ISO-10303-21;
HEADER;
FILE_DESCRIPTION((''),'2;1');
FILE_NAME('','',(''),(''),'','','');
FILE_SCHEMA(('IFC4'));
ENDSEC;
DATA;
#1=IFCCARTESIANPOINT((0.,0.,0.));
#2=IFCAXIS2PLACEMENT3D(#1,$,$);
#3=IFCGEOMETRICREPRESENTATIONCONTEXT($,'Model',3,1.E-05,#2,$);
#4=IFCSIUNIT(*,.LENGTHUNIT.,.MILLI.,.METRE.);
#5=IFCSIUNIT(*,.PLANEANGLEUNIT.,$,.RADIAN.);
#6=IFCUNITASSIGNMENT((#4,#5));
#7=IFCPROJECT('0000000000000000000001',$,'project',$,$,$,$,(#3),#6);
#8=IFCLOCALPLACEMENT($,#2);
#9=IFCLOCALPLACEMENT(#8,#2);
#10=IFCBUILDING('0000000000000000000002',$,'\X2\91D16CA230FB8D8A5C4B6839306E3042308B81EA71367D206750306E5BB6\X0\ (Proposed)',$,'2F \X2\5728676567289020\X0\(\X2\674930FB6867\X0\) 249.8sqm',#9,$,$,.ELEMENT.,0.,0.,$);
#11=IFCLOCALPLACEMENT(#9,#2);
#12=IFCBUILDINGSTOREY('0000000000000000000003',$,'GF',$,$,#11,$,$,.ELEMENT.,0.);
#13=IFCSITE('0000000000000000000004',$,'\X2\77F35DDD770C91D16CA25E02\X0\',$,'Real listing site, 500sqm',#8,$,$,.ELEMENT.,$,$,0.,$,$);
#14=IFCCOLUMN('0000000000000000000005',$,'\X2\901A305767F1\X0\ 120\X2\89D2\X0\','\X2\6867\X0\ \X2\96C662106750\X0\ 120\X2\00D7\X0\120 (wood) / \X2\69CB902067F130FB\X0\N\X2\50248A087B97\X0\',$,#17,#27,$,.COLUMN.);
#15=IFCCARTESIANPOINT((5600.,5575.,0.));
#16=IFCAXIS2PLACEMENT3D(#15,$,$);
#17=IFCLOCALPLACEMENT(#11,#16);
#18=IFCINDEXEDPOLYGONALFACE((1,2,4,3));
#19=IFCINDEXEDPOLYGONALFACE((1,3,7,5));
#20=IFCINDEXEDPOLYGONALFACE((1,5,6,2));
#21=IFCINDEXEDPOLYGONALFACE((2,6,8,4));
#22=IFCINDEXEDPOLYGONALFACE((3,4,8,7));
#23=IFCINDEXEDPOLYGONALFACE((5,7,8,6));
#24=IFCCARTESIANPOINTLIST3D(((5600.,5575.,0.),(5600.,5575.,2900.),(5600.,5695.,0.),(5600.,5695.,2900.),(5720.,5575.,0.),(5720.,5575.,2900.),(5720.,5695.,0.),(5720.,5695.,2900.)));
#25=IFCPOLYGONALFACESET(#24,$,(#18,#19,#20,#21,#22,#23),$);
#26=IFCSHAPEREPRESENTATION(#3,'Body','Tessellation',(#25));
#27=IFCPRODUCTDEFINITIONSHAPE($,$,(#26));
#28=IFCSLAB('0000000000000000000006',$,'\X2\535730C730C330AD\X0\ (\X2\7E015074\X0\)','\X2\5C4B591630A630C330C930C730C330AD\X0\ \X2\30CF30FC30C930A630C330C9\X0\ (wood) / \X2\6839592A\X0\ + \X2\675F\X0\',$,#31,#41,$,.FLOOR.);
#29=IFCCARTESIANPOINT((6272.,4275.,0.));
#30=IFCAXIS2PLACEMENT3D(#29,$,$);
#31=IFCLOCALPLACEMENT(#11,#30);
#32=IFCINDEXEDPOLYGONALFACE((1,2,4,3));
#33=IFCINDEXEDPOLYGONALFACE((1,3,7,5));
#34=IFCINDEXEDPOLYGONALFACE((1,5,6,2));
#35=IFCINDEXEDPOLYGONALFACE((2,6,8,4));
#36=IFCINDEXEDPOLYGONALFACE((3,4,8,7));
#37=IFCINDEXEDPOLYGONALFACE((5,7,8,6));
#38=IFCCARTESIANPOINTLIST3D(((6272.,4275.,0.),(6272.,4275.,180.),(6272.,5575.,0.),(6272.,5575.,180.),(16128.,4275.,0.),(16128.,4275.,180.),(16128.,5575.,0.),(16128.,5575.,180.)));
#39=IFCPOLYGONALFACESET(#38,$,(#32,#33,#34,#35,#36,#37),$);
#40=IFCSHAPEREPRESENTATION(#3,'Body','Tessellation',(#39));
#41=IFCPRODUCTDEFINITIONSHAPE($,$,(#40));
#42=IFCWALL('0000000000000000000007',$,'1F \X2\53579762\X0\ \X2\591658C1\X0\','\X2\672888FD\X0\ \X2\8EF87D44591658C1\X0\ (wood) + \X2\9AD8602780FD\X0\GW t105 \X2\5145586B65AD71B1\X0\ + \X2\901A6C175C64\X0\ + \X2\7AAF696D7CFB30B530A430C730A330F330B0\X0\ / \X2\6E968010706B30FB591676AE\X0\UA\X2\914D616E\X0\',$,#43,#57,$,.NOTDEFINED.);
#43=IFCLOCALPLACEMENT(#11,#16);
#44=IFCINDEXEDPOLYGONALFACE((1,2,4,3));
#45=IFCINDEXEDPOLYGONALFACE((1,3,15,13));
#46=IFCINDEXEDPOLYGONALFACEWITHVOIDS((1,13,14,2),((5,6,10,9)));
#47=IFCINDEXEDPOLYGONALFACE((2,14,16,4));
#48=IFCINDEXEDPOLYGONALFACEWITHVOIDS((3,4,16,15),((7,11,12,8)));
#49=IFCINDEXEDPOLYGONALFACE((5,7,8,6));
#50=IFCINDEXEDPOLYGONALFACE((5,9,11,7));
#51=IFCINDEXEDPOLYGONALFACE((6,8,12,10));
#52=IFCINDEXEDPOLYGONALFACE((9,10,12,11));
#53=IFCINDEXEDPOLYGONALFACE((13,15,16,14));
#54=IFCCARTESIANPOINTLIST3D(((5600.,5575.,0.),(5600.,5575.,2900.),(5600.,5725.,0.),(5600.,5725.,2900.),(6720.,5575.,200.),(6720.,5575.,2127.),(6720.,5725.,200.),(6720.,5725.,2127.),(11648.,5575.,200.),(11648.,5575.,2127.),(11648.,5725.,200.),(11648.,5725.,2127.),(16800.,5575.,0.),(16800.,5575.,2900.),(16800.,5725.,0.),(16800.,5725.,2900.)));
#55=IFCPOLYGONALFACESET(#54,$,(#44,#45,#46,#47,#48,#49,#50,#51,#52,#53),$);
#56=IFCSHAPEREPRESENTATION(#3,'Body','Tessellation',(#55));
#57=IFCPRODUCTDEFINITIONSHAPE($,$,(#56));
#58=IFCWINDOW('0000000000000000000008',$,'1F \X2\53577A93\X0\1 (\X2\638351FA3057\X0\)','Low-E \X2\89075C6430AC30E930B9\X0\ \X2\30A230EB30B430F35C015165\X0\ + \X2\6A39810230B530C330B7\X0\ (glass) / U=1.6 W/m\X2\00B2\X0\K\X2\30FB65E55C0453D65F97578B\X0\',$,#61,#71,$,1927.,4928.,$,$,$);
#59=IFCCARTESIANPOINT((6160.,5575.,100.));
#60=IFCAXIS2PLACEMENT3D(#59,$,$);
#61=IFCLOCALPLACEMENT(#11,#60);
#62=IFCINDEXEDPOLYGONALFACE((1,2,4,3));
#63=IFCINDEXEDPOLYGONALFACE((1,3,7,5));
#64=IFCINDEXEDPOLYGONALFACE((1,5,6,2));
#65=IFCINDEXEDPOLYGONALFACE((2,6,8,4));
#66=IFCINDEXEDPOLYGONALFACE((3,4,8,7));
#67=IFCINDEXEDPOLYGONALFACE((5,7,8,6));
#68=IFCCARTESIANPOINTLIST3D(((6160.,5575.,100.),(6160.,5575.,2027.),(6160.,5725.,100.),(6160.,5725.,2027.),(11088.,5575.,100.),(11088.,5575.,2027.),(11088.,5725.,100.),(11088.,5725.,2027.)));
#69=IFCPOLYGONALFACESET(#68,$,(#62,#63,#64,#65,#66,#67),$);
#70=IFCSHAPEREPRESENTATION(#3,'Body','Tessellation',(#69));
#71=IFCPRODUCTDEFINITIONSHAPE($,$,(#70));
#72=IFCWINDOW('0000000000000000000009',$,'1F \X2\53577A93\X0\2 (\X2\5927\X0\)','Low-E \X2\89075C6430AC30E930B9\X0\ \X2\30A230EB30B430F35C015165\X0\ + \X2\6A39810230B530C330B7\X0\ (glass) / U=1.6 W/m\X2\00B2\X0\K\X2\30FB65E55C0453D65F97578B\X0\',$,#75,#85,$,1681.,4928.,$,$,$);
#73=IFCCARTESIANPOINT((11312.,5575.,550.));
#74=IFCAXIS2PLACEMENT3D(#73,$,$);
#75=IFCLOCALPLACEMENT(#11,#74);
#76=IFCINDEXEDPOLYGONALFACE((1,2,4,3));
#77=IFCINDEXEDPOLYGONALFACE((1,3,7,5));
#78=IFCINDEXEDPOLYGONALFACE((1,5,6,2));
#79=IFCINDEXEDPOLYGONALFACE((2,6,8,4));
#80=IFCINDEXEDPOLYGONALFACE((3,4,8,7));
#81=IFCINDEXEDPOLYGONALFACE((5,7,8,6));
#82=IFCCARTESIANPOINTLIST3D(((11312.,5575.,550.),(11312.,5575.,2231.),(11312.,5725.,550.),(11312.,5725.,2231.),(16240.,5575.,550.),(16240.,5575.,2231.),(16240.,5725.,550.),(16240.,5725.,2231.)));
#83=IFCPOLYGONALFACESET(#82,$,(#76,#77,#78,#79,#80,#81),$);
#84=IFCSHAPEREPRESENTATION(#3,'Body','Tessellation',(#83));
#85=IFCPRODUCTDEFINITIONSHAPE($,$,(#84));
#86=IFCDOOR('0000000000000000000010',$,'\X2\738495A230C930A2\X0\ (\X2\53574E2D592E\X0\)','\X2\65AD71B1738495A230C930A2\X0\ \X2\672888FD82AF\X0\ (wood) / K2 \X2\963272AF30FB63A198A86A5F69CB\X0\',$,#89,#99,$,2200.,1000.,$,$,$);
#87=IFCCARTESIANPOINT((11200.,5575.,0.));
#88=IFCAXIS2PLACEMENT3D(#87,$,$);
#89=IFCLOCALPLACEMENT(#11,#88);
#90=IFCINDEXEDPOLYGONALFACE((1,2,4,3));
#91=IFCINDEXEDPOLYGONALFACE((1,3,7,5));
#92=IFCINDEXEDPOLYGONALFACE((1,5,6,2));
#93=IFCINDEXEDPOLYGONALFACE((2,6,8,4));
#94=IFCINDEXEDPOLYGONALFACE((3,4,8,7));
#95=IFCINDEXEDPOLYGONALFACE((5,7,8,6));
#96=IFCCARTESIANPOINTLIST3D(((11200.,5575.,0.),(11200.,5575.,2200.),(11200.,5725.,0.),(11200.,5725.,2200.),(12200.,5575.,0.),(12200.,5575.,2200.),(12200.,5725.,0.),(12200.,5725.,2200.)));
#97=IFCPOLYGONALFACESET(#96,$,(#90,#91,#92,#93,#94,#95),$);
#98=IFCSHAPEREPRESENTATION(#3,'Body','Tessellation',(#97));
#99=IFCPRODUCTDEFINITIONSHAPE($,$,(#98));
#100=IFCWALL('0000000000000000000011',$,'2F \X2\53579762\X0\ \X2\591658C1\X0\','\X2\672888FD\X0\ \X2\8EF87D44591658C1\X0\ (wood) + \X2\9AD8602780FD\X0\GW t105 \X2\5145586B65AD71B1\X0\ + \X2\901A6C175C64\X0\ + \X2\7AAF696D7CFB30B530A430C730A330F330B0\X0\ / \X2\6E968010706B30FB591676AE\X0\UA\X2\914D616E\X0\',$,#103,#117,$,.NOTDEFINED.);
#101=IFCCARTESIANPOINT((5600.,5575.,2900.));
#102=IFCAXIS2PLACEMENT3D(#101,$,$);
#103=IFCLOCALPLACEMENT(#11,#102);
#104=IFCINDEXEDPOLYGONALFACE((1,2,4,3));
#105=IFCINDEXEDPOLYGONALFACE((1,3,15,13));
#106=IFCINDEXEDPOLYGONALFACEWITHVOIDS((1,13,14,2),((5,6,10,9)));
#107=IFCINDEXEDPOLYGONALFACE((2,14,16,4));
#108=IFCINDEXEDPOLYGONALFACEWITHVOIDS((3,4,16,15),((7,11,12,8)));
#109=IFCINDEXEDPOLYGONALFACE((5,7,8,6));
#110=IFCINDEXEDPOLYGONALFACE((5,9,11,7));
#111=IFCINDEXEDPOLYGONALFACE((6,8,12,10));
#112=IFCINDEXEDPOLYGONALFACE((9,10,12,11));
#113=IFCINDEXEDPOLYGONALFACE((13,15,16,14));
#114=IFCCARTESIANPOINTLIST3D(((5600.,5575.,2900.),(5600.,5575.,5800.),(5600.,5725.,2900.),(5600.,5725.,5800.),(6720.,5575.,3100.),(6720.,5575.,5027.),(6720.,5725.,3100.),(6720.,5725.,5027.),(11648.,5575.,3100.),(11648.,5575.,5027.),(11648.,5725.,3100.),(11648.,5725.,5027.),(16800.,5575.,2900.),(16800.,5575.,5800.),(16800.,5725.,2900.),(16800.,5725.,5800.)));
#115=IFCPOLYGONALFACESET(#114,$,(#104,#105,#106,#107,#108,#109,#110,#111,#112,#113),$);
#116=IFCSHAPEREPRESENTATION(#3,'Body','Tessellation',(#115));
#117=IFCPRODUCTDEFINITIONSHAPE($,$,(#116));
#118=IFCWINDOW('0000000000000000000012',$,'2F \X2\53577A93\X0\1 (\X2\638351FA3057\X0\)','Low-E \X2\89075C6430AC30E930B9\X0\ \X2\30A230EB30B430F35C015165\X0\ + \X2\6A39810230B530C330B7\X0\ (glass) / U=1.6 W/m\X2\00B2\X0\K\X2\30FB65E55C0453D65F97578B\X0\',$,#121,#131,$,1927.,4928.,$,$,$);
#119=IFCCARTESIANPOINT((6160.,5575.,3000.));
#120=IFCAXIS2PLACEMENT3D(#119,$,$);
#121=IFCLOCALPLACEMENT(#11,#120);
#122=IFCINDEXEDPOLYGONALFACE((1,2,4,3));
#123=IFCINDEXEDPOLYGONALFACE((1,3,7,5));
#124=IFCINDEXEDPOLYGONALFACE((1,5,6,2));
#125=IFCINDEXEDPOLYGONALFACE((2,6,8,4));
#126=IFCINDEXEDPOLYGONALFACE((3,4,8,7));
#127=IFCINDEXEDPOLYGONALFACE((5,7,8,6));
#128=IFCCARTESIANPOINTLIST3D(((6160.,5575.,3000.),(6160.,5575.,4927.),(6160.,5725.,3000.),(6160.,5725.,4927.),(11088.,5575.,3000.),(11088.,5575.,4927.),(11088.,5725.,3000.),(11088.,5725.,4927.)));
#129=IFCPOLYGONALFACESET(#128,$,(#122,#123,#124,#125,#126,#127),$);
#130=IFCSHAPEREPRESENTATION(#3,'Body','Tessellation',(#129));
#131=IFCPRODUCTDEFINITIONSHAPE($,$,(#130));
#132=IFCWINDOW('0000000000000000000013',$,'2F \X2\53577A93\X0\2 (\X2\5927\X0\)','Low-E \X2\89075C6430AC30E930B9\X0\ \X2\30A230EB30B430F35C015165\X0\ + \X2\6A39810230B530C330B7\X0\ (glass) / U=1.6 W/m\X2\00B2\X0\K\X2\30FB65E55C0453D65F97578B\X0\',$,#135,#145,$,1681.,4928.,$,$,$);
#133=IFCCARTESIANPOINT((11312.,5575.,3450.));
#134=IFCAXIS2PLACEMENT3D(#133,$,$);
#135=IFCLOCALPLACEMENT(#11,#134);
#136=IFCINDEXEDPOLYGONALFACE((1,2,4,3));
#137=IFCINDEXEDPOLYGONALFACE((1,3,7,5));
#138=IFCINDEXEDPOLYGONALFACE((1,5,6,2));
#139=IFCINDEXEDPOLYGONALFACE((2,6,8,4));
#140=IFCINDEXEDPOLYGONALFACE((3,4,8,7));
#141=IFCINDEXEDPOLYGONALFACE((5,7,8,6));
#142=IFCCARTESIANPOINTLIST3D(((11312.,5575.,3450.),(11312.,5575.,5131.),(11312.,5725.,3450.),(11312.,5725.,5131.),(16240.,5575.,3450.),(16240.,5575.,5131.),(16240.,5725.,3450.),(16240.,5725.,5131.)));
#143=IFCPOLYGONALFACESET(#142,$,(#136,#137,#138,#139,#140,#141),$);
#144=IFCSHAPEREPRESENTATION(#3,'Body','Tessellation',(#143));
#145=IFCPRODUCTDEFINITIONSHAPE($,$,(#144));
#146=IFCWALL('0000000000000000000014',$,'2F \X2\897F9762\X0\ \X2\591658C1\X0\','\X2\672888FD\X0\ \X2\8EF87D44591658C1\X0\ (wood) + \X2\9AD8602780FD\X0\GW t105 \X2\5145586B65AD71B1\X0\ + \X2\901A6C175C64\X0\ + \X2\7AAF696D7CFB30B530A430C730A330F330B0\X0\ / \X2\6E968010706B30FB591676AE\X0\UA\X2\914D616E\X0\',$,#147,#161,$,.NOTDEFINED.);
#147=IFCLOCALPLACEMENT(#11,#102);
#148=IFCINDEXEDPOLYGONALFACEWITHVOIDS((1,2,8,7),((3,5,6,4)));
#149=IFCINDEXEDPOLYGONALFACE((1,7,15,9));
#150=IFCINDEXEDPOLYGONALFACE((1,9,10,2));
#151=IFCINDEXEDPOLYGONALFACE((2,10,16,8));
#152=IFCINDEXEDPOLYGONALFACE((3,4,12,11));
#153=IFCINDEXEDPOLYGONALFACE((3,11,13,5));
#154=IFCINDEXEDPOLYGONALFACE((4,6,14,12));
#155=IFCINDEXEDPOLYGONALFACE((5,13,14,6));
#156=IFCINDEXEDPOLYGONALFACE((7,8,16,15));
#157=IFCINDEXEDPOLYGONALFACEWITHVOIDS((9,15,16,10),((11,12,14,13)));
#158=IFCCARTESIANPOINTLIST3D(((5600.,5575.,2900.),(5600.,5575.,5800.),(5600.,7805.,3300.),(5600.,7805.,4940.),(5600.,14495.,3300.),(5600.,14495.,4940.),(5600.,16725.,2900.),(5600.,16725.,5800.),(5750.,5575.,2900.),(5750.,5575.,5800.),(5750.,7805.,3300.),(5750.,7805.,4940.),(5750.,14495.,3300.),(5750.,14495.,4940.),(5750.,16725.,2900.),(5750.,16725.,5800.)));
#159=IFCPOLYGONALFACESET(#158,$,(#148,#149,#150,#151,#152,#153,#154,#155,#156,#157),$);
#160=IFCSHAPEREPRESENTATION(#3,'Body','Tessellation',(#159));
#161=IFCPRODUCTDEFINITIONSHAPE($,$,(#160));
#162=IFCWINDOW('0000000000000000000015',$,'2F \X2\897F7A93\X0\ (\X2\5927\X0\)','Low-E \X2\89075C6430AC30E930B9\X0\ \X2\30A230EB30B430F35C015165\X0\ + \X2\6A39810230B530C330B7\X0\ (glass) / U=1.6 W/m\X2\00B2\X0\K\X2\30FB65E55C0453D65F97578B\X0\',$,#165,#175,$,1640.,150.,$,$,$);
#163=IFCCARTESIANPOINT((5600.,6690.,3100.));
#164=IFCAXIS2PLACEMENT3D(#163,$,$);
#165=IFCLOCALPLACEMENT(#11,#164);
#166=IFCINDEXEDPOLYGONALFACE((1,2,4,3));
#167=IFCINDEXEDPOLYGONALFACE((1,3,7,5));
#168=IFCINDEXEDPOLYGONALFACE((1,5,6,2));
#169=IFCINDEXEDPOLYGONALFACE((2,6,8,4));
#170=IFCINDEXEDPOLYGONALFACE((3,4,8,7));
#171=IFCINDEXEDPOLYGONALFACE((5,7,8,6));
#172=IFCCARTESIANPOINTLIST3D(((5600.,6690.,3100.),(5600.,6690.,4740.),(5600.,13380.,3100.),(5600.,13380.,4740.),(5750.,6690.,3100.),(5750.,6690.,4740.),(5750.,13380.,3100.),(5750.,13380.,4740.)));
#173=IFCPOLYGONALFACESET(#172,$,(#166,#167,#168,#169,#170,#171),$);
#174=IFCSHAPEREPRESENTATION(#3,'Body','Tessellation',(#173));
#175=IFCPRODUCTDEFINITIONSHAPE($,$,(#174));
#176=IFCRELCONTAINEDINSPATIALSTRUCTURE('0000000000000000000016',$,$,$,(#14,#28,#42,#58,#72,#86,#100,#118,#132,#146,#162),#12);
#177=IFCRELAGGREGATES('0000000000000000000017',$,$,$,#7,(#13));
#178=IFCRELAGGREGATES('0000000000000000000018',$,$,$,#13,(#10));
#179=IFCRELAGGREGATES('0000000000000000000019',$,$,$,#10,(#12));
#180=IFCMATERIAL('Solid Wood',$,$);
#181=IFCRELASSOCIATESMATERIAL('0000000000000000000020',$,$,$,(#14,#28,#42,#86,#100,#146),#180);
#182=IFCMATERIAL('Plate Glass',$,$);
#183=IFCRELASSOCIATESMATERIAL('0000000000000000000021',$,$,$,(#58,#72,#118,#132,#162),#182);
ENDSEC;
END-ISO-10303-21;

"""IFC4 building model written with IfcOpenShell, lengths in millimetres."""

from ifc_helpers import new_model, si_unit, frame, frame_2d, origin, place, context, project, spatial, rectangle, extrude, material, element, fill, save


model = new_model("IFC4")

# Units and contexts
model_context = context("Model", 3, precision=1e-05, world=origin())
ifc_project = project(units=[si_unit("LENGTHUNIT", "METRE", prefix="MILLI"), si_unit("PLANEANGLEUNIT", "RADIAN")], contexts=[model_context])

# Site, building, storey
site_placement = place(None, origin())
site = spatial("IfcSite", under=ifc_project, at=site_placement, Name="石川県金沢市", ObjectType="Real listing site, 500sqm", CompositionType="ELEMENT", RefElevation=0.0)
building_placement = place(site_placement, origin())
building = spatial("IfcBuilding", under=site, at=building_placement, Name="金沢・越屋根のある自然素材の家 (Proposed)", ObjectType="2F 在来木造(杉・桧) 249.8sqm", CompositionType="ELEMENT", ElevationOfRefHeight=0.0, ElevationOfTerrain=0.0)
storey_placement = place(building_placement, origin())
storey = spatial("IfcBuildingStorey", under=building, at=storey_placement, Name="GF", CompositionType="ELEMENT", Elevation=0.0)

# Column
ifc_material_1 = material(Name="Solid Wood")
column_placement = place(storey_placement, frame((5600.0, 5575.0, 0.0)))
element("IfcColumn", 1, at=column_placement, inside=storey, material=ifc_material_1, Name="通し柱 120角", Description="桧 集成材 120×120 (wood) / 構造柱・N値計算", PredefinedType="COLUMN", context=model_context, shape_type="SweptSolid", body=[
    extrude(rectangle(XDim=120.0, YDim=120.0, at=frame_2d((60.0, 60.0))), frame((5600.0, 5575.0, 0.0)), (0.0, 0.0, 1.0), 2900.0),
])

# Slab
slab_1_placement = place(storey_placement, frame((6272.0, 4275.0, 0.0)))
element("IfcSlab", 2, at=slab_1_placement, inside=storey, material=ifc_material_1, Name="南デッキ (縁側)", Description="屋外ウッドデッキ ハードウッド (wood) / 根太 + 束", PredefinedType="FLOOR", context=model_context, shape_type="SweptSolid", body=[
    extrude(rectangle(XDim=9856.0, YDim=1300.0, at=frame_2d((4928.0, 650.0))), frame((6272.0, 4275.0, 0.0)), (0.0, 0.0, 1.0), 180.0),
])

# Wall, openings, windows, door
wall_1_placement = place(storey_placement, frame((5600.0, 5575.0, 0.0)))
wall_1 = element("IfcWall", 3, at=wall_1_placement, inside=storey, material=ifc_material_1, Name="1F 南面 外壁", Description="木製 軸組外壁 (wood) + 高性能GW t105 充填断熱 + 通気層 + 窯業系サイディング / 準耐火・外皮UA配慮", PredefinedType="NOTDEFINED", context=model_context, shape_type="SweptSolid", body=[
    extrude(rectangle(XDim=11200.0, YDim=150.0, at=frame_2d((5600.0, 75.0))), frame((5600.0, 5575.0, 0.0)), (0.0, 0.0, 1.0), 2900.0),
])
opening_1_placement = place(storey_placement, frame((6160.0, 5575.0, 100.0)))
opening_1 = element("IfcOpeningElement", 4, at=opening_1_placement, cuts=wall_1, PredefinedType="NOTDEFINED", context=model_context, shape_type="SweptSolid", body=[
    extrude(rectangle(XDim=4928.0, YDim=150.0, at=frame_2d((2464.0, 75.0))), frame((6160.0, 5575.0, 100.0)), (0.0, 0.0, 1.0), 1927.0),
])
opening_2_placement = place(storey_placement, frame((11312.0, 5575.0, 550.0)))
opening_2 = element("IfcOpeningElement", 5, at=opening_2_placement, cuts=wall_1, PredefinedType="NOTDEFINED", context=model_context, shape_type="SweptSolid", body=[
    extrude(rectangle(XDim=4928.0, YDim=150.0, at=frame_2d((2464.0, 75.0))), frame((11312.0, 5575.0, 550.0)), (0.0, 0.0, 1.0), 1681.0),
])
opening_3_placement = place(storey_placement, frame((11200.0, 5575.0, 0.0)))
opening_3 = element("IfcOpeningElement", 6, at=opening_3_placement, cuts=wall_1, PredefinedType="NOTDEFINED", context=model_context, shape_type="SweptSolid", body=[
    extrude(rectangle(XDim=1000.0, YDim=150.0, at=frame_2d((500.0, 75.0))), frame((11200.0, 5575.0, 0.0)), (0.0, 0.0, 1.0), 2200.0),
])
ifc_material_2 = material(Name="Plate Glass")
window_1_placement = place(storey_placement, frame((6160.0, 5575.0, 100.0)))
window_1 = element("IfcWindow", 7, at=window_1_placement, inside=storey, material=ifc_material_2, Name="1F 南窓1 (掃出し)", Description="Low-E 複層ガラス アルゴン封入 + 樹脂サッシ (glass) / U=1.6 W/m²K・日射取得型", OverallHeight=1927.0, OverallWidth=4928.0, context=model_context, shape_type="SweptSolid", body=[
    extrude(rectangle(XDim=4928.0, YDim=150.0, at=frame_2d((2464.0, 75.0))), frame((6160.0, 5575.0, 100.0)), (0.0, 0.0, 1.0), 1927.0),
])
fill(opening_1, window_1)
window_2_placement = place(storey_placement, frame((11312.0, 5575.0, 550.0)))
window_2 = element("IfcWindow", 8, at=window_2_placement, inside=storey, material=ifc_material_2, Name="1F 南窓2 (大)", Description="Low-E 複層ガラス アルゴン封入 + 樹脂サッシ (glass) / U=1.6 W/m²K・日射取得型", OverallHeight=1681.0, OverallWidth=4928.0, context=model_context, shape_type="SweptSolid", body=[
    extrude(rectangle(XDim=4928.0, YDim=150.0, at=frame_2d((2464.0, 75.0))), frame((11312.0, 5575.0, 550.0)), (0.0, 0.0, 1.0), 1681.0),
])
fill(opening_2, window_2)
door_placement = place(storey_placement, frame((11200.0, 5575.0, 0.0)))
door = element("IfcDoor", 9, at=door_placement, inside=storey, material=ifc_material_1, Name="玄関ドア (南中央)", Description="断熱玄関ドア 木製芯 (wood) / K2 防犯・採風機構", OverallHeight=2200.0, OverallWidth=1000.0, context=model_context, shape_type="SweptSolid", body=[
    extrude(rectangle(XDim=1000.0, YDim=150.0, at=frame_2d((500.0, 75.0))), frame((11200.0, 5575.0, 0.0)), (0.0, 0.0, 1.0), 2200.0),
])
fill(opening_3, door)

# Wall, openings, windows
wall_2_placement = place(storey_placement, frame((5600.0, 5575.0, 2900.0)))
wall_2 = element("IfcWall", 10, at=wall_2_placement, inside=storey, material=ifc_material_1, Name="2F 南面 外壁", Description="木製 軸組外壁 (wood) + 高性能GW t105 充填断熱 + 通気層 + 窯業系サイディング / 準耐火・外皮UA配慮", PredefinedType="NOTDEFINED", context=model_context, shape_type="SweptSolid", body=[
    extrude(rectangle(XDim=11200.0, YDim=150.0, at=frame_2d((5600.0, 75.0))), frame((5600.0, 5575.0, 2900.0)), (0.0, 0.0, 1.0), 2900.0),
])
opening_4_placement = place(storey_placement, frame((6160.0, 5575.0, 3000.0)))
opening_4 = element("IfcOpeningElement", 11, at=opening_4_placement, cuts=wall_2, PredefinedType="NOTDEFINED", context=model_context, shape_type="SweptSolid", body=[
    extrude(rectangle(XDim=4928.0, YDim=150.0, at=frame_2d((2464.0, 75.0))), frame((6160.0, 5575.0, 3000.0)), (0.0, 0.0, 1.0), 1927.0),
])
opening_5_placement = place(storey_placement, frame((11312.0, 5575.0, 3450.0)))
opening_5 = element("IfcOpeningElement", 12, at=opening_5_placement, cuts=wall_2, PredefinedType="NOTDEFINED", context=model_context, shape_type="SweptSolid", body=[
    extrude(rectangle(XDim=4928.0, YDim=150.0, at=frame_2d((2464.0, 75.0))), frame((11312.0, 5575.0, 3450.0)), (0.0, 0.0, 1.0), 1681.0),
])
window_3_placement = place(storey_placement, frame((6160.0, 5575.0, 3000.0)))
window_3 = element("IfcWindow", 13, at=window_3_placement, inside=storey, material=ifc_material_2, Name="2F 南窓1 (掃出し)", Description="Low-E 複層ガラス アルゴン封入 + 樹脂サッシ (glass) / U=1.6 W/m²K・日射取得型", OverallHeight=1927.0, OverallWidth=4928.0, context=model_context, shape_type="SweptSolid", body=[
    extrude(rectangle(XDim=4928.0, YDim=150.0, at=frame_2d((2464.0, 75.0))), frame((6160.0, 5575.0, 3000.0)), (0.0, 0.0, 1.0), 1927.0),
])
fill(opening_4, window_3)
window_4_placement = place(storey_placement, frame((11312.0, 5575.0, 3450.0)))
window_4 = element("IfcWindow", 14, at=window_4_placement, inside=storey, material=ifc_material_2, Name="2F 南窓2 (大)", Description="Low-E 複層ガラス アルゴン封入 + 樹脂サッシ (glass) / U=1.6 W/m²K・日射取得型", OverallHeight=1681.0, OverallWidth=4928.0, context=model_context, shape_type="SweptSolid", body=[
    extrude(rectangle(XDim=4928.0, YDim=150.0, at=frame_2d((2464.0, 75.0))), frame((11312.0, 5575.0, 3450.0)), (0.0, 0.0, 1.0), 1681.0),
])
fill(opening_5, window_4)

# Wall, opening, window
wall_3_placement = place(storey_placement, frame((5600.0, 5575.0, 2900.0)))
wall_3 = element("IfcWall", 15, at=wall_3_placement, inside=storey, material=ifc_material_1, Name="2F 西面 外壁", Description="木製 軸組外壁 (wood) + 高性能GW t105 充填断熱 + 通気層 + 窯業系サイディング / 準耐火・外皮UA配慮", PredefinedType="NOTDEFINED", context=model_context, shape_type="SweptSolid", body=[
    extrude(rectangle(XDim=150.0, YDim=11150.0, at=frame_2d((75.0, 5575.0))), frame((5600.0, 5575.0, 2900.0)), (0.0, 0.0, 1.0), 2900.0),
])
opening_6_placement = place(storey_placement, frame((5600.0, 6690.0, 3100.0)))
opening_6 = element("IfcOpeningElement", 16, at=opening_6_placement, cuts=wall_3, PredefinedType="NOTDEFINED", context=model_context, shape_type="SweptSolid", body=[
    extrude(rectangle(XDim=150.0, YDim=6690.0, at=frame_2d((75.0, 3345.0))), frame((5600.0, 6690.0, 3100.0)), (0.0, 0.0, 1.0), 1640.0),
])
window_5_placement = place(storey_placement, frame((5600.0, 6690.0, 3100.0)))
window_5 = element("IfcWindow", 17, at=window_5_placement, inside=storey, material=ifc_material_2, Name="2F 西窓 (大)", Description="Low-E 複層ガラス アルゴン封入 + 樹脂サッシ (glass) / U=1.6 W/m²K・日射取得型", OverallHeight=1640.0, OverallWidth=150.0, context=model_context, shape_type="SweptSolid", body=[
    extrude(rectangle(XDim=150.0, YDim=6690.0, at=frame_2d((75.0, 3345.0))), frame((5600.0, 6690.0, 3100.0)), (0.0, 0.0, 1.0), 1640.0),
])
fill(opening_6, window_5)

save(model, "model.ifc")
